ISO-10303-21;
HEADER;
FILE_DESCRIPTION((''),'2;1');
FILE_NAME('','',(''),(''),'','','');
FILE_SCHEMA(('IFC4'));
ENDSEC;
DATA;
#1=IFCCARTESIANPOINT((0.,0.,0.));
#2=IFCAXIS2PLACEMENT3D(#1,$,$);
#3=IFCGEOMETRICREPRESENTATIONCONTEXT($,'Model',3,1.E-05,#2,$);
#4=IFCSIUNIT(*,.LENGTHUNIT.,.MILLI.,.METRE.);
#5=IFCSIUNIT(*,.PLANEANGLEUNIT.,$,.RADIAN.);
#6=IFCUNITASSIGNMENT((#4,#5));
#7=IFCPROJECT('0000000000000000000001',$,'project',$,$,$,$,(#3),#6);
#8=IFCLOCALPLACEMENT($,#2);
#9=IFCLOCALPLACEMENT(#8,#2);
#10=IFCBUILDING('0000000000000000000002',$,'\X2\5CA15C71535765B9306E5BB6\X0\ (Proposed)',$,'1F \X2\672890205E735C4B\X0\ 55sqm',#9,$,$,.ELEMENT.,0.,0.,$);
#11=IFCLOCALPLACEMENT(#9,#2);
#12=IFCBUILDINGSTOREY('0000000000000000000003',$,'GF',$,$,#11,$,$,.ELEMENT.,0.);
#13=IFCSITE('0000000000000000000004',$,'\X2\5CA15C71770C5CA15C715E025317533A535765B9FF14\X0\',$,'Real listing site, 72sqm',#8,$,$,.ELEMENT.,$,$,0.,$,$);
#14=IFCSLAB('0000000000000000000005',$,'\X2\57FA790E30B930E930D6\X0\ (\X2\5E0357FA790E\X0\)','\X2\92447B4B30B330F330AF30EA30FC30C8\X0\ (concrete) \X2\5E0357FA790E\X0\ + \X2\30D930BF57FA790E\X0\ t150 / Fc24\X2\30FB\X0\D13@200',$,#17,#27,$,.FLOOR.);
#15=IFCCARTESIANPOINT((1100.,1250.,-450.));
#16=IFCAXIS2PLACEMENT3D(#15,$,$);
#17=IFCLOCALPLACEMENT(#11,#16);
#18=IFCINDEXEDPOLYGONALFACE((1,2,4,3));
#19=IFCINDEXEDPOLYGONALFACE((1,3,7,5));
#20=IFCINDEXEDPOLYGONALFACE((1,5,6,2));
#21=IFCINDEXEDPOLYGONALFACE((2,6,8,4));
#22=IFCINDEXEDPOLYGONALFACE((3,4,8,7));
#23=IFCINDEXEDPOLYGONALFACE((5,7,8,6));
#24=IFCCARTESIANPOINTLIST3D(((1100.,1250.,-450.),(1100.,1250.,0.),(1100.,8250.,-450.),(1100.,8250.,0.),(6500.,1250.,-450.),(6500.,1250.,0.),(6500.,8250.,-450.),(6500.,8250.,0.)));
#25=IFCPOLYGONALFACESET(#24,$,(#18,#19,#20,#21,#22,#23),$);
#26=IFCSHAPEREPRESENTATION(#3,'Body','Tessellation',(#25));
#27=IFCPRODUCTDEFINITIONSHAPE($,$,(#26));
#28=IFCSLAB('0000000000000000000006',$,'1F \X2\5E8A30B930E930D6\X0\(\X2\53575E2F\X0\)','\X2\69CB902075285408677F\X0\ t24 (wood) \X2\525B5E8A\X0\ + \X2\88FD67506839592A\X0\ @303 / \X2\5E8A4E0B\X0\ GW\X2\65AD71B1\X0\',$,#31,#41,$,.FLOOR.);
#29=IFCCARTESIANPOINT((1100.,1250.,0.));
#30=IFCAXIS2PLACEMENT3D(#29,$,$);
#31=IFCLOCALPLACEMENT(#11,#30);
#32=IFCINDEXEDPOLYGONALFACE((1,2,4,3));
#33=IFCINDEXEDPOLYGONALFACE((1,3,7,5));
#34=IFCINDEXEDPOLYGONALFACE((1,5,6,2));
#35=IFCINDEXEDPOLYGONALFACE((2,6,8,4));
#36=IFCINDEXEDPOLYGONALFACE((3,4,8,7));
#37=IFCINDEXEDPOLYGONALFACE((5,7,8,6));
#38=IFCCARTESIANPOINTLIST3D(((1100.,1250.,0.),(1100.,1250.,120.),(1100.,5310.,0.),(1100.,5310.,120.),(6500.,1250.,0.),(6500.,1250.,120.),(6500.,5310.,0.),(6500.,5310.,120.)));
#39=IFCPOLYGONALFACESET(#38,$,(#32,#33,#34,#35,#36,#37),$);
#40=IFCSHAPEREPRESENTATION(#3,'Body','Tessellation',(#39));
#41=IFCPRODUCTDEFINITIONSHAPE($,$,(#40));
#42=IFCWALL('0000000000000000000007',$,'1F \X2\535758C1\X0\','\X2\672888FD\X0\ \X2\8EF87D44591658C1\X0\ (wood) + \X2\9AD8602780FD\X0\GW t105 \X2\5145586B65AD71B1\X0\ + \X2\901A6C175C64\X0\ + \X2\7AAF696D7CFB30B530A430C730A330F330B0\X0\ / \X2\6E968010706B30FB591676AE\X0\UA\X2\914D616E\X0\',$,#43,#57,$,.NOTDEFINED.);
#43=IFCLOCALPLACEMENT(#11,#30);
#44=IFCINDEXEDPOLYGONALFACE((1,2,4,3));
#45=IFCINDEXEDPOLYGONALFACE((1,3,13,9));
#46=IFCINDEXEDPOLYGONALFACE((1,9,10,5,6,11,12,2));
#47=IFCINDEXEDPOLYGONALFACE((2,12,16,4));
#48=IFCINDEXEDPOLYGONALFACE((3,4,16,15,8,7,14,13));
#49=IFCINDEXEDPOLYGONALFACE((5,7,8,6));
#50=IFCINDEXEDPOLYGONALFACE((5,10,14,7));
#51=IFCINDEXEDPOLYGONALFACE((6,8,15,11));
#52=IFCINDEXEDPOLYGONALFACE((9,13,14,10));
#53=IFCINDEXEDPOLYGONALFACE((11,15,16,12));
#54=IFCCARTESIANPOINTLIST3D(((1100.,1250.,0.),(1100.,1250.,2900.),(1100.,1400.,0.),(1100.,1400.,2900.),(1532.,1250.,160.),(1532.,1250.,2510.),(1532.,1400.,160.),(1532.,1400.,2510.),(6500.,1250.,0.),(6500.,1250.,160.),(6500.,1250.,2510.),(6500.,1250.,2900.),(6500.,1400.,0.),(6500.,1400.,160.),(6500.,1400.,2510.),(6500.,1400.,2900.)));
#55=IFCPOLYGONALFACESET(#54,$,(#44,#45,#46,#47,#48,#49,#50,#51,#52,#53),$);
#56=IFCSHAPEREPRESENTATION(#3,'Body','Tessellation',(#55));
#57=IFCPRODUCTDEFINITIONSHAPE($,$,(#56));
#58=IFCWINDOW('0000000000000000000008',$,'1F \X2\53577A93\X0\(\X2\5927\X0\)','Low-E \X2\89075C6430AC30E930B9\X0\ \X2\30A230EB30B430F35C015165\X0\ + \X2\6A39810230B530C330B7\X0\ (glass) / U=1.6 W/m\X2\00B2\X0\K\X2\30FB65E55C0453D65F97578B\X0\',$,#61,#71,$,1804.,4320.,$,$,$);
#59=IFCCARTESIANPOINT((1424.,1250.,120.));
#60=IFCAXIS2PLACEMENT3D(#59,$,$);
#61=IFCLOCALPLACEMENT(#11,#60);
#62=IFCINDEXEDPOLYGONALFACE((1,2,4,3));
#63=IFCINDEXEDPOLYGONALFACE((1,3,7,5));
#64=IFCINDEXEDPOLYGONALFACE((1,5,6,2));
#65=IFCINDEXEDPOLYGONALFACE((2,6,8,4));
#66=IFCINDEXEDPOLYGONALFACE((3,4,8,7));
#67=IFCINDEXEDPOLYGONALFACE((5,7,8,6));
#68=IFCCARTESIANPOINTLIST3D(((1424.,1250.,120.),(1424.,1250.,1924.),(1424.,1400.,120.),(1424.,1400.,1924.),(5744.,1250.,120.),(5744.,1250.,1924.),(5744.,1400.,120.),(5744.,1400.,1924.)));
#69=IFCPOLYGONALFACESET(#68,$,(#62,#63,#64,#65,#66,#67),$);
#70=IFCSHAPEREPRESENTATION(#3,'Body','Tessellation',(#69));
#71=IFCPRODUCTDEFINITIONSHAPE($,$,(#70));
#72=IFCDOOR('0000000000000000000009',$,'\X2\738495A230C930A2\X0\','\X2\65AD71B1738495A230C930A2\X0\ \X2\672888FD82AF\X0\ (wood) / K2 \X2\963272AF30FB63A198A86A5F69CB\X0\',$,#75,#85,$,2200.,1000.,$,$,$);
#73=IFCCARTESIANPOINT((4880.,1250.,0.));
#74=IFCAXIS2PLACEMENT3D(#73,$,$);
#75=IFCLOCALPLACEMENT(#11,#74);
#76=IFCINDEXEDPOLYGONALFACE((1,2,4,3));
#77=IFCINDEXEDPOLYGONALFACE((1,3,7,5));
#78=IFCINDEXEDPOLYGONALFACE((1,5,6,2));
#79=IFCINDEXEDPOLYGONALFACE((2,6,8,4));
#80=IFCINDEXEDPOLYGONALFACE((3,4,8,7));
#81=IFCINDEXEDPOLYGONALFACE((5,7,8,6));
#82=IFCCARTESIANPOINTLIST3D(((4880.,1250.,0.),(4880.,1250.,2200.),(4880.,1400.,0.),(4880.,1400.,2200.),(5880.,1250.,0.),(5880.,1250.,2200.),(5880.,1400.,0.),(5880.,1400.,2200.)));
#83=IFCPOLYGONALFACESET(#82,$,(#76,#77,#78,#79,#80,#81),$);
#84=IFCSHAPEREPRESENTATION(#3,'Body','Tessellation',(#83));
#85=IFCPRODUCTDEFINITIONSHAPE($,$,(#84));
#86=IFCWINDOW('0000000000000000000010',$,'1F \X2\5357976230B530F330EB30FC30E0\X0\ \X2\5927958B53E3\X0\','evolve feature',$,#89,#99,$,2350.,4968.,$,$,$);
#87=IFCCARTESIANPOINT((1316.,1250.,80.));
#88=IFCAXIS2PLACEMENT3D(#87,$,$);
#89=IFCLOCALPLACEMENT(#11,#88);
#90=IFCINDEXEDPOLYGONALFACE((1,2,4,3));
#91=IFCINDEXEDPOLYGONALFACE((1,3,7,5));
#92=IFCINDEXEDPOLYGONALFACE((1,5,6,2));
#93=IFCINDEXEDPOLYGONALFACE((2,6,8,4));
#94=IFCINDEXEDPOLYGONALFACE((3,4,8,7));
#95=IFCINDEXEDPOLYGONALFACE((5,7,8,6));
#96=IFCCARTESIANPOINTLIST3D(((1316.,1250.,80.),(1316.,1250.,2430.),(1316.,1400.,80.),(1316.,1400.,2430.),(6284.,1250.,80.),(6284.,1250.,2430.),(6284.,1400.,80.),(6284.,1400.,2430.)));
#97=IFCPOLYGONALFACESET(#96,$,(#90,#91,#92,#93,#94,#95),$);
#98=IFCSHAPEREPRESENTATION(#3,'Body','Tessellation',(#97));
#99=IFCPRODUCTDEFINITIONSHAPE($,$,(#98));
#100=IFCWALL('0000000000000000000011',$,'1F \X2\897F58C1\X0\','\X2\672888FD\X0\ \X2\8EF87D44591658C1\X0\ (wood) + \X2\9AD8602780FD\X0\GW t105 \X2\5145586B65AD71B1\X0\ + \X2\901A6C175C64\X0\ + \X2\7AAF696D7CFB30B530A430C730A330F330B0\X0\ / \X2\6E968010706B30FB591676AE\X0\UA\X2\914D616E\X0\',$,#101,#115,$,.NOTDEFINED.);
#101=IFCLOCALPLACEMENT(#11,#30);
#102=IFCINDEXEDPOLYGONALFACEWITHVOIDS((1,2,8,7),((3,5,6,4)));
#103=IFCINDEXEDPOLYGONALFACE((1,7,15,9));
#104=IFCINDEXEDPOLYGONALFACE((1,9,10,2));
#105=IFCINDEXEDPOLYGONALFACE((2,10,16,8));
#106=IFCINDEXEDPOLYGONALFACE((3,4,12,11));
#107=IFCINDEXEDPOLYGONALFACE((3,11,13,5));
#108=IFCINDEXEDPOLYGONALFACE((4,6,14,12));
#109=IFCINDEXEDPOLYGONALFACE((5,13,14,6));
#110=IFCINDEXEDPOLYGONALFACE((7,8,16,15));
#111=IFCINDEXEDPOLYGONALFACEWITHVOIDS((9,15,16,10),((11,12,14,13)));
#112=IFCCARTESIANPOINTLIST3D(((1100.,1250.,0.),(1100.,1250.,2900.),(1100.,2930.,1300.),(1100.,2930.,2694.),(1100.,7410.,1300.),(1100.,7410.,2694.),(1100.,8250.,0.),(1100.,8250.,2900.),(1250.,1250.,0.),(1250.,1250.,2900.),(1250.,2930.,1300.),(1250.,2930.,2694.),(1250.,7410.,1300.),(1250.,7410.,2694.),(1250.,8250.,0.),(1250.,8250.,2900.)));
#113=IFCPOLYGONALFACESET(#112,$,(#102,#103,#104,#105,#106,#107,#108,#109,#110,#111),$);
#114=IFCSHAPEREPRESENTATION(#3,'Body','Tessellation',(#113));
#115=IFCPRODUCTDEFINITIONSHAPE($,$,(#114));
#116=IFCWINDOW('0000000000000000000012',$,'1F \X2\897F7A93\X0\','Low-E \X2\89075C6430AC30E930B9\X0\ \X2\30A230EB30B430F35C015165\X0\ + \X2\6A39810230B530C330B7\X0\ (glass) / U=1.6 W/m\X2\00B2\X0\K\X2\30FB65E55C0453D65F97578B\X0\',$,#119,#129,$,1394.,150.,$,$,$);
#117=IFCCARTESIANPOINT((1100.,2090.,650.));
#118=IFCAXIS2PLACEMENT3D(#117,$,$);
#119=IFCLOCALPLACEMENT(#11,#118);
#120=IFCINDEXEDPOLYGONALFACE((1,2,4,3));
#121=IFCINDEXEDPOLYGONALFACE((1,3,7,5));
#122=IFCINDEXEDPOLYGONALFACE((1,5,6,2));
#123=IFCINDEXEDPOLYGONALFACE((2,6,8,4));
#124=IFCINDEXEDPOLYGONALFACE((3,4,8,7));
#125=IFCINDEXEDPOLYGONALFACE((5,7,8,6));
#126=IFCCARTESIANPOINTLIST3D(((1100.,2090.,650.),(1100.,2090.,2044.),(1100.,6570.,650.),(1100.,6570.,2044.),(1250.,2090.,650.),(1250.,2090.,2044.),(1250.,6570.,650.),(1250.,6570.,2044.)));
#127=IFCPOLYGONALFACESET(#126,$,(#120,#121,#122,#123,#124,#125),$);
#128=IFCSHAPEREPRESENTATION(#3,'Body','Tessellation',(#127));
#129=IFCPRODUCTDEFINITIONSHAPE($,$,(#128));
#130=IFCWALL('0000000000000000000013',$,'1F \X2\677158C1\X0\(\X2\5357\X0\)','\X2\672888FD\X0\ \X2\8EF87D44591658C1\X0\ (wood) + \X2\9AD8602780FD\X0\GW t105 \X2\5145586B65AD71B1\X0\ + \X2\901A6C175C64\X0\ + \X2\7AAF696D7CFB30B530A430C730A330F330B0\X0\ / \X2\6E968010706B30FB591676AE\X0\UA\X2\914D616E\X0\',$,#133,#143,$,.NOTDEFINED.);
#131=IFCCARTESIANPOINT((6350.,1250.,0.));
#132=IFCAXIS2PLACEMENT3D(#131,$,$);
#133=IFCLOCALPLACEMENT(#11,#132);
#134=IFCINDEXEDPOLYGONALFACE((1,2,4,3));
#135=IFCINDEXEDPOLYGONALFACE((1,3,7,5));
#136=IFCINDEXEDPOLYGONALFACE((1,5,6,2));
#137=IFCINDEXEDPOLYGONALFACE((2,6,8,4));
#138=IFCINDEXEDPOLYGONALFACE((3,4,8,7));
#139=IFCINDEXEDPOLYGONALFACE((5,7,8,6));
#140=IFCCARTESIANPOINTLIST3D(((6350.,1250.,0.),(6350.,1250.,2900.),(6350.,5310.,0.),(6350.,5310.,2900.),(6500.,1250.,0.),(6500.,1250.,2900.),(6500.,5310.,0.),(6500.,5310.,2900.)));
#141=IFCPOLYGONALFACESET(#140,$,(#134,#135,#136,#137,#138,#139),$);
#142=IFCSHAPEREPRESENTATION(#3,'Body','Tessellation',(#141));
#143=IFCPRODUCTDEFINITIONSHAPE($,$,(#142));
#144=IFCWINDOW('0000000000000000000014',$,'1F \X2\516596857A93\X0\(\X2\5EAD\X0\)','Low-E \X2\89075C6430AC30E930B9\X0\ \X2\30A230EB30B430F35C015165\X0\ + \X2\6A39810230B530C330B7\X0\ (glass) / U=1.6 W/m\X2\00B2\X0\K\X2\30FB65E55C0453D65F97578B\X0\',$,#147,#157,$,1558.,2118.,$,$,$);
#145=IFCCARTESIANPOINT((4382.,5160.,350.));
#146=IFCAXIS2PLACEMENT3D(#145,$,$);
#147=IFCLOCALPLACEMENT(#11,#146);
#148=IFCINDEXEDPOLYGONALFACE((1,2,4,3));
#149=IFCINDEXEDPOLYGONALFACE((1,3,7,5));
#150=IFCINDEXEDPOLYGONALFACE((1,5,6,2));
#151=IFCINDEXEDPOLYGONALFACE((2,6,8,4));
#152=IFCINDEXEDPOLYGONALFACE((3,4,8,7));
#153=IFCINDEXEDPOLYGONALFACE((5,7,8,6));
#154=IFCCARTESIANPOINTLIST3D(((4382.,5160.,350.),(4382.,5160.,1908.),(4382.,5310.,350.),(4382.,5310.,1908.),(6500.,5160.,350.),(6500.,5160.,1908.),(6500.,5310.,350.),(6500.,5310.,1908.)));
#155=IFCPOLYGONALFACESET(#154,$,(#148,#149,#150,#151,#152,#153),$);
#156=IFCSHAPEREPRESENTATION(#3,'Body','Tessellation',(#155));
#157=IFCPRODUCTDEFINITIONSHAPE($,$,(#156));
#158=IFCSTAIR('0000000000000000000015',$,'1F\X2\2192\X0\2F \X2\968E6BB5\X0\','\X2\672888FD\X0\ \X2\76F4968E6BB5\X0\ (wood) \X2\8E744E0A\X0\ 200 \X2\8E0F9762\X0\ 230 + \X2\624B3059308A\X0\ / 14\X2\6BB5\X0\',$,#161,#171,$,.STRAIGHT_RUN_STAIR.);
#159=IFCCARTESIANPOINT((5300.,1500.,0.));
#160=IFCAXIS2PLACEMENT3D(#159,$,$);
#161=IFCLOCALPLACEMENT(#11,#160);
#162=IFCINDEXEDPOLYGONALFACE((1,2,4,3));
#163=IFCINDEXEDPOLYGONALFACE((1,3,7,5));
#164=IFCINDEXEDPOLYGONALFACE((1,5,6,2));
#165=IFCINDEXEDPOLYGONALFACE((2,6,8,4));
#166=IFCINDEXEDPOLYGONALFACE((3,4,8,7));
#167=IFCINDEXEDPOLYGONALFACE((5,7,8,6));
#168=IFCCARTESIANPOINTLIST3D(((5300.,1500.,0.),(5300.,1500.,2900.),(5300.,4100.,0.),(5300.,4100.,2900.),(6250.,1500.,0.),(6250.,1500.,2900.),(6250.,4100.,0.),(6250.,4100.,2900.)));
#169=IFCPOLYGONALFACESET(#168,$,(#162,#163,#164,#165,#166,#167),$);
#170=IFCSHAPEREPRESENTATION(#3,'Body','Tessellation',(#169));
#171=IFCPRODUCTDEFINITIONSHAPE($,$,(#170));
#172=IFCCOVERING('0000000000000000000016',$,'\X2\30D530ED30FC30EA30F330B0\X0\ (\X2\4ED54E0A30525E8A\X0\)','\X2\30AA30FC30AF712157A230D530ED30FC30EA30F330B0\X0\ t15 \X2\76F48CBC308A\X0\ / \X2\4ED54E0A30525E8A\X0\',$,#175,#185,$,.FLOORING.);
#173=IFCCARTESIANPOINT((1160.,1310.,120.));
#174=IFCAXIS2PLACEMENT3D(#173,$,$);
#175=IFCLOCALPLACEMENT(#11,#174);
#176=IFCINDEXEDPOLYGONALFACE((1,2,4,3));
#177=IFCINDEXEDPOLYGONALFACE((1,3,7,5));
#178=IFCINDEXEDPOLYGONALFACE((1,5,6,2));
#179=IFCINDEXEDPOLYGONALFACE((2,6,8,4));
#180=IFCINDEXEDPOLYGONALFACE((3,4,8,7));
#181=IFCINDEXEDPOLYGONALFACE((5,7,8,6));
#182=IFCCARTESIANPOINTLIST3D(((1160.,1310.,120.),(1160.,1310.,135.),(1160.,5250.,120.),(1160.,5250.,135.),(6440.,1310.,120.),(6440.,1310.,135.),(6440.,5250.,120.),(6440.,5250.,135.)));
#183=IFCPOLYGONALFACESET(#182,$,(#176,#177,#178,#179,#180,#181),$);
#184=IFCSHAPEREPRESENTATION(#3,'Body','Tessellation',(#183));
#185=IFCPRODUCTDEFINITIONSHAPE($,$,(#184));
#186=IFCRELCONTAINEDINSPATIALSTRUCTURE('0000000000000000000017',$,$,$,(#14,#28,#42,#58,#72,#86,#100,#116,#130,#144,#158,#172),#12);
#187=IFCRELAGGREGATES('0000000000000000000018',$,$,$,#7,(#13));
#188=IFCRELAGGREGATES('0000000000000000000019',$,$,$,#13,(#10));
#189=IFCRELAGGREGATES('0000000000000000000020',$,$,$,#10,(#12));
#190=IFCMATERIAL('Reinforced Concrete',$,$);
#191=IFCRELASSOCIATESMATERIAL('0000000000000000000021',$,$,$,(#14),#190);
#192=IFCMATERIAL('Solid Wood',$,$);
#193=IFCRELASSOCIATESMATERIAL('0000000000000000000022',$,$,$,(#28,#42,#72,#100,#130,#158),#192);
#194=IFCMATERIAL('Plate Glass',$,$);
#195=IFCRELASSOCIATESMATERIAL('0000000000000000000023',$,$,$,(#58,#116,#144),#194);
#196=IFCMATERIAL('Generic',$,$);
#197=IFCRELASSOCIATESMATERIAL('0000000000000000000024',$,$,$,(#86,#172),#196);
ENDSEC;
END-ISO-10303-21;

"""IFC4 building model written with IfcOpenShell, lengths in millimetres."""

from ifc_helpers import new_model, si_unit, frame, frame_2d, origin, place, context, project, spatial, rectangle, extrude, material, element, fill, save


model = new_model("IFC4")

# Units and contexts
model_context = context("Model", 3, precision=1e-05, world=origin())
ifc_project = project(units=[si_unit("LENGTHUNIT", "METRE", prefix="MILLI"), si_unit("PLANEANGLEUNIT", "RADIAN")], contexts=[model_context])

# Site, building, storey
site_placement = place(None, origin())
site = spatial("IfcSite", under=ifc_project, at=site_placement, Name="岡山県岡山市北区南方４", ObjectType="Real listing site, 72sqm", CompositionType="ELEMENT", RefElevation=0.0)
building_placement = place(site_placement, origin())
building = spatial("IfcBuilding", under=site, at=building_placement, Name="岡山南方の家 (Proposed)", ObjectType="1F 木造平屋 55sqm", CompositionType="ELEMENT", ElevationOfRefHeight=0.0, ElevationOfTerrain=0.0)
storey_placement = place(building_placement, origin())
storey = spatial("IfcBuildingStorey", under=building, at=storey_placement, Name="GF", CompositionType="ELEMENT", Elevation=0.0)

# Slabs
ifc_material_1 = material(Name="Reinforced Concrete")
slab_1_placement = place(storey_placement, frame((1100.0, 1250.0, -450.0)))
element("IfcSlab", 1, at=slab_1_placement, inside=storey, material=ifc_material_1, Name="基礎スラブ (布基礎)", Description="鉄筋コンクリート (concrete) 布基礎 + ベタ基礎 t150 / Fc24・D13@200", PredefinedType="FLOOR", context=model_context, shape_type="SweptSolid", body=[
    extrude(rectangle(XDim=5400.0, YDim=7000.0, at=frame_2d((2700.0, 3500.0))), frame((1100.0, 1250.0, -450.0)), (0.0, 0.0, 1.0), 450.0),
])
ifc_material_2 = material(Name="Solid Wood")
slab_2_placement = place(storey_placement, frame((1100.0, 1250.0, 0.0)))
element("IfcSlab", 2, at=slab_2_placement, inside=storey, material=ifc_material_2, Name="1F 床スラブ(南帯)", Description="構造用合板 t24 (wood) 剛床 + 製材根太 @303 / 床下 GW断熱", PredefinedType="FLOOR", context=model_context, shape_type="SweptSolid", body=[
    extrude(rectangle(XDim=5400.0, YDim=4060.0, at=frame_2d((2700.0, 2030.0))), frame((1100.0, 1250.0, 0.0)), (0.0, 0.0, 1.0), 120.0),
])

# Wall, openings, windows, door
wall_1_placement = place(storey_placement, frame((1100.0, 1250.0, 0.0)))
wall_1 = element("IfcWall", 3, at=wall_1_placement, inside=storey, material=ifc_material_2, Name="1F 南壁", Description="木製 軸組外壁 (wood) + 高性能GW t105 充填断熱 + 通気層 + 窯業系サイディング / 準耐火・外皮UA配慮", PredefinedType="NOTDEFINED", context=model_context, shape_type="SweptSolid", body=[
    extrude(rectangle(XDim=5400.0, YDim=150.0, at=frame_2d((2700.0, 75.0))), frame((1100.0, 1250.0, 0.0)), (0.0, 0.0, 1.0), 2900.0),
])
opening_1_placement = place(storey_placement, frame((1424.0, 1250.0, 120.0)))
opening_1 = element("IfcOpeningElement", 4, at=opening_1_placement, cuts=wall_1, PredefinedType="NOTDEFINED", context=model_context, shape_type="SweptSolid", body=[
    extrude(rectangle(XDim=4320.0, YDim=150.0, at=frame_2d((2160.0, 75.0))), frame((1424.0, 1250.0, 120.0)), (0.0, 0.0, 1.0), 1804.0),
])
opening_2_placement = place(storey_placement, frame((4880.0, 1250.0, 0.0)))
opening_2 = element("IfcOpeningElement", 5, at=opening_2_placement, cuts=wall_1, PredefinedType="NOTDEFINED", context=model_context, shape_type="SweptSolid", body=[
    extrude(rectangle(XDim=1000.0, YDim=150.0, at=frame_2d((500.0, 75.0))), frame((4880.0, 1250.0, 0.0)), (0.0, 0.0, 1.0), 2200.0),
])
opening_3_placement = place(storey_placement, frame((1316.0, 1250.0, 80.0)))
opening_3 = element("IfcOpeningElement", 6, at=opening_3_placement, cuts=wall_1, PredefinedType="NOTDEFINED", context=model_context, shape_type="SweptSolid", body=[
    extrude(rectangle(XDim=4968.0, YDim=150.0, at=frame_2d((2484.0, 75.0))), frame((1316.0, 1250.0, 80.0)), (0.0, 0.0, 1.0), 2350.0),
])
ifc_material_3 = material(Name="Plate Glass")
window_1_placement = place(storey_placement, frame((1424.0, 1250.0, 120.0)))
window_1 = element("IfcWindow", 7, at=window_1_placement, inside=storey, material=ifc_material_3, Name="1F 南窓(大)", Description="Low-E 複層ガラス アルゴン封入 + 樹脂サッシ (glass) / U=1.6 W/m²K・日射取得型", OverallHeight=1804.0, OverallWidth=4320.0, context=model_context, shape_type="SweptSolid", body=[
    extrude(rectangle(XDim=4320.0, YDim=150.0, at=frame_2d((2160.0, 75.0))), frame((1424.0, 1250.0, 120.0)), (0.0, 0.0, 1.0), 1804.0),
])
fill(opening_1, window_1)
door_1_placement = place(storey_placement, frame((4880.0, 1250.0, 0.0)))
door_1 = element("IfcDoor", 8, at=door_1_placement, inside=storey, material=ifc_material_2, Name="玄関ドア", Description="断熱玄関ドア 木製芯 (wood) / K2 防犯・採風機構", OverallHeight=2200.0, OverallWidth=1000.0, context=model_context, shape_type="SweptSolid", body=[
    extrude(rectangle(XDim=1000.0, YDim=150.0, at=frame_2d((500.0, 75.0))), frame((4880.0, 1250.0, 0.0)), (0.0, 0.0, 1.0), 2200.0),
])
fill(opening_2, door_1)
ifc_material_4 = material(Name="Generic")
window_2_placement = place(storey_placement, frame((1316.0, 1250.0, 80.0)))
window_2 = element("IfcWindow", 9, at=window_2_placement, inside=storey, material=ifc_material_4, Name="1F 南面サンルーム 大開口", Description="evolve feature", OverallHeight=2350.0, OverallWidth=4968.0, context=model_context, shape_type="SweptSolid", body=[
    extrude(rectangle(XDim=4968.0, YDim=150.0, at=frame_2d((2484.0, 75.0))), frame((1316.0, 1250.0, 80.0)), (0.0, 0.0, 1.0), 2350.0),
])
fill(opening_3, window_2)

# Walls, openings, windows
wall_2_placement = place(storey_placement, frame((1100.0, 1250.0, 0.0)))
wall_2 = element("IfcWall", 10, at=wall_2_placement, inside=storey, material=ifc_material_2, Name="1F 西壁", Description="木製 軸組外壁 (wood) + 高性能GW t105 充填断熱 + 通気層 + 窯業系サイディング / 準耐火・外皮UA配慮", PredefinedType="NOTDEFINED", context=model_context, shape_type="SweptSolid", body=[
    extrude(rectangle(XDim=150.0, YDim=7000.0, at=frame_2d((75.0, 3500.0))), frame((1100.0, 1250.0, 0.0)), (0.0, 0.0, 1.0), 2900.0),
])
opening_4_placement = place(storey_placement, frame((1100.0, 2090.0, 650.0)))
opening_4 = element("IfcOpeningElement", 11, at=opening_4_placement, cuts=wall_2, PredefinedType="NOTDEFINED", context=model_context, shape_type="SweptSolid", body=[
    extrude(rectangle(XDim=150.0, YDim=4480.0, at=frame_2d((75.0, 2240.0))), frame((1100.0, 2090.0, 650.0)), (0.0, 0.0, 1.0), 1394.0),
])
window_3_placement = place(storey_placement, frame((1100.0, 2090.0, 650.0)))
window_3 = element("IfcWindow", 12, at=window_3_placement, inside=storey, material=ifc_material_3, Name="1F 西窓", Description="Low-E 複層ガラス アルゴン封入 + 樹脂サッシ (glass) / U=1.6 W/m²K・日射取得型", OverallHeight=1394.0, OverallWidth=150.0, context=model_context, shape_type="SweptSolid", body=[
    extrude(rectangle(XDim=150.0, YDim=4480.0, at=frame_2d((75.0, 2240.0))), frame((1100.0, 2090.0, 650.0)), (0.0, 0.0, 1.0), 1394.0),
])
fill(opening_4, window_3)
wall_3_placement = place(storey_placement, frame((6350.0, 1250.0, 0.0)))
wall_3 = element("IfcWall", 13, at=wall_3_placement, inside=storey, material=ifc_material_2, Name="1F 東壁(南)", Description="木製 軸組外壁 (wood) + 高性能GW t105 充填断熱 + 通気層 + 窯業系サイディング / 準耐火・外皮UA配慮", PredefinedType="NOTDEFINED", context=model_context, shape_type="SweptSolid", body=[
    extrude(rectangle(XDim=150.0, YDim=4060.0, at=frame_2d((75.0, 2030.0))), frame((6350.0, 1250.0, 0.0)), (0.0, 0.0, 1.0), 2900.0),
])
opening_5_placement = place(storey_placement, frame((4382.0, 5160.0, 350.0)))
opening_5 = element("IfcOpeningElement", 14, at=opening_5_placement, cuts=wall_3, PredefinedType="NOTDEFINED", context=model_context, shape_type="SweptSolid", body=[
    extrude(rectangle(XDim=2118.0, YDim=150.0, at=frame_2d((1059.0, 75.0))), frame((4382.0, 5160.0, 350.0)), (0.0, 0.0, 1.0), 1558.0),
])
window_4_placement = place(storey_placement, frame((4382.0, 5160.0, 350.0)))
window_4 = element("IfcWindow", 15, at=window_4_placement, inside=storey, material=ifc_material_3, Name="1F 入隅窓(庭)", Description="Low-E 複層ガラス アルゴン封入 + 樹脂サッシ (glass) / U=1.6 W/m²K・日射取得型", OverallHeight=1558.0, OverallWidth=2118.0, context=model_context, shape_type="SweptSolid", body=[
    extrude(rectangle(XDim=2118.0, YDim=150.0, at=frame_2d((1059.0, 75.0))), frame((4382.0, 5160.0, 350.0)), (0.0, 0.0, 1.0), 1558.0),
])
fill(opening_5, window_4)

# Stair
stair_placement = place(storey_placement, frame((5300.0, 1500.0, 0.0)))
element("IfcStair", 16, at=stair_placement, inside=storey, material=ifc_material_2, Name="1F→2F 階段", Description="木製 直階段 (wood) 蹴上 200 踏面 230 + 手すり / 14段", PredefinedType="STRAIGHT_RUN_STAIR", context=model_context, shape_type="SweptSolid", body=[
    extrude(rectangle(XDim=950.0, YDim=2600.0, at=frame_2d((475.0, 1300.0))), frame((5300.0, 1500.0, 0.0)), (0.0, 0.0, 1.0), 2900.0),
])

# Covering
covering_placement = place(storey_placement, frame((1160.0, 1310.0, 120.0)))
element("IfcCovering", 17, at=covering_placement, inside=storey, material=ifc_material_4, Name="フローリング (仕上げ床)", Description="オーク無垢フローリング t15 直貼り / 仕上げ床", PredefinedType="FLOORING", context=model_context, shape_type="SweptSolid", body=[
    extrude(rectangle(XDim=5280.0, YDim=3940.0, at=frame_2d((2640.0, 1970.0))), frame((1160.0, 1310.0, 120.0)), (0.0, 0.0, 1.0), 15.0),
])

save(model, "model.ifc")
